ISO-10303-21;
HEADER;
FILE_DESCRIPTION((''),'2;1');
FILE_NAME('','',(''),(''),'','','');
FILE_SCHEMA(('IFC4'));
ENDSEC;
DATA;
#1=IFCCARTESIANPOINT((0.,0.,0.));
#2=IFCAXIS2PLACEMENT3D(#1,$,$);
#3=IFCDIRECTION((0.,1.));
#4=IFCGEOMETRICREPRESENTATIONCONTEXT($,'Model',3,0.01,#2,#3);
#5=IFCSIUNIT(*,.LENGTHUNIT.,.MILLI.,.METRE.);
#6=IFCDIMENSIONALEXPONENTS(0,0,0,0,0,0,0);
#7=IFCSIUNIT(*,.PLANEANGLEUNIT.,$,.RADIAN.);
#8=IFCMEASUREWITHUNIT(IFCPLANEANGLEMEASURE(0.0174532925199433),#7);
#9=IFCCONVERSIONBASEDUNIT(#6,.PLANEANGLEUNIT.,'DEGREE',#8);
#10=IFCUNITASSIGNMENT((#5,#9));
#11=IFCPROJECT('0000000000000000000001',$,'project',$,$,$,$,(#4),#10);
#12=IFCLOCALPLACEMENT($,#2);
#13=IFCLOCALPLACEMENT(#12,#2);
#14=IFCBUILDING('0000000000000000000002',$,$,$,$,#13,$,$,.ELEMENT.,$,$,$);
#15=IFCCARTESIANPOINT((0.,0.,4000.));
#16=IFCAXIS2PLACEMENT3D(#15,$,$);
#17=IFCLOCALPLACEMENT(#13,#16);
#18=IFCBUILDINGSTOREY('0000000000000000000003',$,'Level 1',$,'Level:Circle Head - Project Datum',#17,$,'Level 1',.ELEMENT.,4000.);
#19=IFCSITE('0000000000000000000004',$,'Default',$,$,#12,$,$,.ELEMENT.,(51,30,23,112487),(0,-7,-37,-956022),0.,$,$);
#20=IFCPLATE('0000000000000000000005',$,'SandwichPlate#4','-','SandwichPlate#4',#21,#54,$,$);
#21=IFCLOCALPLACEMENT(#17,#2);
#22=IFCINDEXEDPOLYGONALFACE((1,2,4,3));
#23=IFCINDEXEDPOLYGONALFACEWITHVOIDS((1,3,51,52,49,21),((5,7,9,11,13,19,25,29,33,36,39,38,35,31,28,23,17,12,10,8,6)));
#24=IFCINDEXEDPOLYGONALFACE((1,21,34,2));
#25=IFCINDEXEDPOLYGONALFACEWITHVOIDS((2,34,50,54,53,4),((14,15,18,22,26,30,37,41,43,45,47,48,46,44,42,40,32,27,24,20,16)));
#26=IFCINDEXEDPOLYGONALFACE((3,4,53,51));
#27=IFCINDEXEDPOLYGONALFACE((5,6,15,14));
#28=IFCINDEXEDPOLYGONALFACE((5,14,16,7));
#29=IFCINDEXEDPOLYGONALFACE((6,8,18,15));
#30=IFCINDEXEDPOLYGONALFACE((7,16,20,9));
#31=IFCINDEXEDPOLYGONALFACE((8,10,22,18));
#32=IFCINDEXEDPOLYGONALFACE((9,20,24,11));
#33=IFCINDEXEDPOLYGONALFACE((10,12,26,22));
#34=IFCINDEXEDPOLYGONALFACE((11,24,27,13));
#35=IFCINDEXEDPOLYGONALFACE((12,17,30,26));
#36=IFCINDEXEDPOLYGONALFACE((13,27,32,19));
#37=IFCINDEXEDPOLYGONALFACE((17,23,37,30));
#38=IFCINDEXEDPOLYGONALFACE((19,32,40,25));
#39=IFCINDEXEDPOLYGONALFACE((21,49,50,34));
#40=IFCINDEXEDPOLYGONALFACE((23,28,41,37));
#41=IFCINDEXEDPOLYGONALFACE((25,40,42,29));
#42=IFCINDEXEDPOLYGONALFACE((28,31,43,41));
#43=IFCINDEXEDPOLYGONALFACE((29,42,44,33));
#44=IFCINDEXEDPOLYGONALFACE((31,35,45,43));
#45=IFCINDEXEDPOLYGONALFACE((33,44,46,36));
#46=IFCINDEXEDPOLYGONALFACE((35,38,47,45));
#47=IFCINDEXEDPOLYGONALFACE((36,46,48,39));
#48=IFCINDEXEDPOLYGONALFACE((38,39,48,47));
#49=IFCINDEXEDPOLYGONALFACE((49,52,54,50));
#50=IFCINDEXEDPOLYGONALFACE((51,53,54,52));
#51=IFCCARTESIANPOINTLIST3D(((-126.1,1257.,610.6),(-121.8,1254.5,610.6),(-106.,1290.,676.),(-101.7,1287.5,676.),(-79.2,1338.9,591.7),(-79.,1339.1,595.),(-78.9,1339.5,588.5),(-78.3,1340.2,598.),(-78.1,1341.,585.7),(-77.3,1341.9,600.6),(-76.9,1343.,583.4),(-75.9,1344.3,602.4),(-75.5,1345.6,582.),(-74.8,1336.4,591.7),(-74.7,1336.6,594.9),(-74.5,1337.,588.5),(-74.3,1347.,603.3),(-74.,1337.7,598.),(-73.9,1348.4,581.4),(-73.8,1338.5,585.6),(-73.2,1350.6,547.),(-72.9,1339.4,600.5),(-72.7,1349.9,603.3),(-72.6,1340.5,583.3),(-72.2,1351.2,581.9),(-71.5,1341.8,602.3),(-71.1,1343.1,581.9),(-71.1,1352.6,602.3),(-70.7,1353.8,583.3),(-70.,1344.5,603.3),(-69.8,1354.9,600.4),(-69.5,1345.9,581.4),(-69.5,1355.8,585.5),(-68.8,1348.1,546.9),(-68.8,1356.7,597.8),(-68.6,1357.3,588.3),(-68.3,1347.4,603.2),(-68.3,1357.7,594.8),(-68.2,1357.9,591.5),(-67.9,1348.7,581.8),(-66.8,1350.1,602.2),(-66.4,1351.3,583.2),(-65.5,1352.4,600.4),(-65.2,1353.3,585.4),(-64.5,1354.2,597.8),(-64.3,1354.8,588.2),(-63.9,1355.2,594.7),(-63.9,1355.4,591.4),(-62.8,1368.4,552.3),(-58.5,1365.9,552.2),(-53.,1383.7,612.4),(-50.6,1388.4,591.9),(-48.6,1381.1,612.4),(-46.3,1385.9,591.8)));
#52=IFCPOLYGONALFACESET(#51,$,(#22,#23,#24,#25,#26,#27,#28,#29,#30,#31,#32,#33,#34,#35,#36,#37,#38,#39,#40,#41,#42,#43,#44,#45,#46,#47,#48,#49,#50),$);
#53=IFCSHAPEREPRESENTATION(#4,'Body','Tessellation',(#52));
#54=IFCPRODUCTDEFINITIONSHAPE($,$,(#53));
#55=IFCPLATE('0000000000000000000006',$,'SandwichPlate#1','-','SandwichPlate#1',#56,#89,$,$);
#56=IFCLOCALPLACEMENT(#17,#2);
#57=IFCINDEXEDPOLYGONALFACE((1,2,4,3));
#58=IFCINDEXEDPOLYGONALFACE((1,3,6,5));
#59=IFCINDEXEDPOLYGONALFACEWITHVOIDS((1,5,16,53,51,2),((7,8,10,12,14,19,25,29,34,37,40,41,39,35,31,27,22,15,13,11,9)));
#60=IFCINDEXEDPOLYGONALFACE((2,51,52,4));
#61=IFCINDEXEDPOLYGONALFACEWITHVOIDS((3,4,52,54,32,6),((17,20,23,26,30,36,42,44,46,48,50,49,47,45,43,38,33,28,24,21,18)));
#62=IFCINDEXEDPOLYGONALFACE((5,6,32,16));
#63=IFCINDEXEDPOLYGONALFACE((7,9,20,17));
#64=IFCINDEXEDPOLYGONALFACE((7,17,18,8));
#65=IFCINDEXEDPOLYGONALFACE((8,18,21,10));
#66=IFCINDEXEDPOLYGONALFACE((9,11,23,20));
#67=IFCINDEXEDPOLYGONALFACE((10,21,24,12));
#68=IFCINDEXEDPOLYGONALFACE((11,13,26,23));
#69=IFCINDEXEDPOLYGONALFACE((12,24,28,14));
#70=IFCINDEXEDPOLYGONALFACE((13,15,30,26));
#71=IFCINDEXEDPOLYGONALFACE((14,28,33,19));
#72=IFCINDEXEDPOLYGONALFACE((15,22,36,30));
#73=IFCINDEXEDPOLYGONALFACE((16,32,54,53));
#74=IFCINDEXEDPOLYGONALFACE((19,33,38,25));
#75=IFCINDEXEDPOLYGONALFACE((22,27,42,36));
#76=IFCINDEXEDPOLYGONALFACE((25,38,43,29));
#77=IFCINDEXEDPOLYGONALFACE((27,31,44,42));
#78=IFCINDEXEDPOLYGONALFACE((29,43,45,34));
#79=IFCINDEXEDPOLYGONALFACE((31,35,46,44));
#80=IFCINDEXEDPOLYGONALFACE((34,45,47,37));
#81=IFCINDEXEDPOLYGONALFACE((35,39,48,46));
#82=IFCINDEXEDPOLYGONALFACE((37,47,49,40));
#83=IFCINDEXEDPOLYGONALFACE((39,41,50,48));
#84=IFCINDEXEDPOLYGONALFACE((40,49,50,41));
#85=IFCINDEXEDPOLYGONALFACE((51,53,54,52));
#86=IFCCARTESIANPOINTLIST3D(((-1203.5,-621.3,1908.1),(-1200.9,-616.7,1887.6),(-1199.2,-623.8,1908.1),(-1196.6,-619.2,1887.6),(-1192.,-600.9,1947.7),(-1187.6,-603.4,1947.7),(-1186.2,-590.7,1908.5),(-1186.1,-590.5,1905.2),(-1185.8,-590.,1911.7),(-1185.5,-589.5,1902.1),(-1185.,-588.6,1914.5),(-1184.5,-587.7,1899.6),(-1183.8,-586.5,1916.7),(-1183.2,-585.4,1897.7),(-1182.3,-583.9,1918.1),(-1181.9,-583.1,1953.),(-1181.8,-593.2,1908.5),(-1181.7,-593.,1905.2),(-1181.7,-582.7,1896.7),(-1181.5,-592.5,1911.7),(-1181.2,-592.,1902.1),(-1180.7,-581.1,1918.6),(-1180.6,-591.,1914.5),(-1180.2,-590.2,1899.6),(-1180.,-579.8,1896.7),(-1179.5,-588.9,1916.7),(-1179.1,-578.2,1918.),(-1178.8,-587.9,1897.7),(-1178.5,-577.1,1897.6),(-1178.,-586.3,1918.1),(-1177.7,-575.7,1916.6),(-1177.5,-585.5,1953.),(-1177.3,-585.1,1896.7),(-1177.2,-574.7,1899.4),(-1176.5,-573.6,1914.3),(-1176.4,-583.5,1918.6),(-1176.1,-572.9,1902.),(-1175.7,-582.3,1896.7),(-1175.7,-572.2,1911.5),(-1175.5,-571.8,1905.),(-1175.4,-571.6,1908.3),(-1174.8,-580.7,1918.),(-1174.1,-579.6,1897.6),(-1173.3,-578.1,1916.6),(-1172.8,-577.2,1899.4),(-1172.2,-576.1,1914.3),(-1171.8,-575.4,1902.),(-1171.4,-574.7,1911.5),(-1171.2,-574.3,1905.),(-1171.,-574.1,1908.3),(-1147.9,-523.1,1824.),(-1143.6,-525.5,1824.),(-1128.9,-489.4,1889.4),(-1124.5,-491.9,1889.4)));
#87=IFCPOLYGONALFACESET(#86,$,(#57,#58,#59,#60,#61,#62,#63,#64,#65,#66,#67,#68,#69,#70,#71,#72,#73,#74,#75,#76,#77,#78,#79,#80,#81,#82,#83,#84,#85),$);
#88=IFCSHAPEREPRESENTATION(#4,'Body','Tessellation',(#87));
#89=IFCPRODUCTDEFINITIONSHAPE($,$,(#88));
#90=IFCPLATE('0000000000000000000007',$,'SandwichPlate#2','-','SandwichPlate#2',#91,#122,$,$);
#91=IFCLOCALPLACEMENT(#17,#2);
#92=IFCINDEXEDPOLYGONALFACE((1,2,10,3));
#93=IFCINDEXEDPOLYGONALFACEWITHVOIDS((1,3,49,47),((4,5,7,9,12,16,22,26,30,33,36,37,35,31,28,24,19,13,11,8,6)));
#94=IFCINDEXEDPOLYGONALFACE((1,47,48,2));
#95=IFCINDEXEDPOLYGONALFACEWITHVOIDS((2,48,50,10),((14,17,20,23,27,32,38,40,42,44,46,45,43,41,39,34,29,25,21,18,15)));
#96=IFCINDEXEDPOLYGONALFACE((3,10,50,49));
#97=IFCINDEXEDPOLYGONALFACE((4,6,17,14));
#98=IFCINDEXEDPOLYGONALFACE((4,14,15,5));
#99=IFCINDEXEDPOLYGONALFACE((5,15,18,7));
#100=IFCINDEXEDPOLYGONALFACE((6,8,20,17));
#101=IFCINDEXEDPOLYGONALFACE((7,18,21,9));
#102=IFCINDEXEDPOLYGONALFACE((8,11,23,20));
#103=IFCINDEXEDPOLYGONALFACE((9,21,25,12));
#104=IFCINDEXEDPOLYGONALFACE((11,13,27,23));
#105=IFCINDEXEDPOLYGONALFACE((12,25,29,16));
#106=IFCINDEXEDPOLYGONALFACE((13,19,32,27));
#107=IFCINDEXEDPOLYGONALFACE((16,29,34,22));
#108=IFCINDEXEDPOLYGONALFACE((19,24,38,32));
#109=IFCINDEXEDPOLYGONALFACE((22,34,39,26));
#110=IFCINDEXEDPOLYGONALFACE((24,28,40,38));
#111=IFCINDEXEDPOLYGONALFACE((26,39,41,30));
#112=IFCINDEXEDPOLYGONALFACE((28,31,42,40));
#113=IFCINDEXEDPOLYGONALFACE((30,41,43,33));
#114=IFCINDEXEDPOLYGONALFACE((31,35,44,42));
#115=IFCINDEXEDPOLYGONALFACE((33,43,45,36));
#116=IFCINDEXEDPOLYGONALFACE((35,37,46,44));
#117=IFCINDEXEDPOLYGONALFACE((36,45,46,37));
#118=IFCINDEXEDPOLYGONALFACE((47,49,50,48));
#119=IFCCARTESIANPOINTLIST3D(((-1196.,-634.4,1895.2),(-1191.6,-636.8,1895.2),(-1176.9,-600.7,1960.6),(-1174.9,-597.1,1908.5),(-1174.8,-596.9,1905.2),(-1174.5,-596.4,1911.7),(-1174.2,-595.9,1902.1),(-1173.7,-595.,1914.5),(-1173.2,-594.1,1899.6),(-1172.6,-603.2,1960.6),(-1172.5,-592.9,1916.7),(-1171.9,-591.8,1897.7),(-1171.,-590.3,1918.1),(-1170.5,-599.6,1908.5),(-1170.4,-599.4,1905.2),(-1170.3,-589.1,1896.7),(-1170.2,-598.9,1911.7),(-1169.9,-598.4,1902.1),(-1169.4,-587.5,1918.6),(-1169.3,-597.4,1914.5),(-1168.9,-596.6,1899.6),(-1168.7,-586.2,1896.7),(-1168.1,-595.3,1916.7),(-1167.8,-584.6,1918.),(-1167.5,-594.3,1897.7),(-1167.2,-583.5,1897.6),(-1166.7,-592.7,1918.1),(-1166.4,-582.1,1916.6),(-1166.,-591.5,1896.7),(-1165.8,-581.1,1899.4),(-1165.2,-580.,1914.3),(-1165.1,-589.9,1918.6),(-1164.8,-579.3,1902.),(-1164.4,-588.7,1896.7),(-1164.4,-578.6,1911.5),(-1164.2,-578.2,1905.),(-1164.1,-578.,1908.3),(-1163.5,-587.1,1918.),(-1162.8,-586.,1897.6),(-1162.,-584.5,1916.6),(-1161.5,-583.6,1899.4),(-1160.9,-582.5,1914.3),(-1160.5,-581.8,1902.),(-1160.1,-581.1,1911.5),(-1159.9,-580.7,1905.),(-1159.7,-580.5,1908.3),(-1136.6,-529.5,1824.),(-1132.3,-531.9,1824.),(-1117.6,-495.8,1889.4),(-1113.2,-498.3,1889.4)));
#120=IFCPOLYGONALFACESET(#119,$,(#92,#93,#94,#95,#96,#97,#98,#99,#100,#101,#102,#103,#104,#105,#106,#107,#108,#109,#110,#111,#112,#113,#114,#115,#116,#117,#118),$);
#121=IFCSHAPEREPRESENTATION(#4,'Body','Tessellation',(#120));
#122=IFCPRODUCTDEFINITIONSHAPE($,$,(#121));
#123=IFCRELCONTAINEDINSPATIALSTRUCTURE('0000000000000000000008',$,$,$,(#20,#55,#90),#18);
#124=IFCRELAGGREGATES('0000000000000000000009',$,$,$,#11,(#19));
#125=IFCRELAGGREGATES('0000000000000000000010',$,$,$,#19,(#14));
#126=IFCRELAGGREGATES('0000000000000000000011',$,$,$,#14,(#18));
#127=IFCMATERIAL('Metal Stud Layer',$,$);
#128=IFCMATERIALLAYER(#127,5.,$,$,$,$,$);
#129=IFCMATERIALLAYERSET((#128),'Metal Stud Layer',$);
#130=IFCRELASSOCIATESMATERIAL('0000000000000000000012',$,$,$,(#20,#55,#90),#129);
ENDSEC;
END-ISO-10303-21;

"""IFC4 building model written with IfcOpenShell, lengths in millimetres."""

from ifc_helpers import new_model, entity, si_unit, converted_unit, direction, frame, origin, origin_with_axes, origin_2d_with_axis, place, context, project, spatial, polyline, circle, outline, extrude, material, layer, layer_set, element, save


model = new_model("IFC4")

# Units and contexts
model_context = context("Model", 3, precision=0.01, world=origin(), true_north=direction((0.0, 1.0)))
ifc_project = project(units=[si_unit("LENGTHUNIT", "METRE", prefix="MILLI"), converted_unit("PLANEANGLEUNIT", "DEGREE", entity("IfcPlaneAngleMeasure", 0.0174532925199433), si_unit("PLANEANGLEUNIT", "RADIAN"), dimensions=[0, 0, 0, 0, 0, 0, 0])], contexts=[model_context])

# Site, building, storey
site_placement = place(None, origin())
site = spatial("IfcSite", under=ifc_project, at=site_placement, Name="Default", CompositionType="ELEMENT", RefLatitude=(51, 30, 23, 112487), RefLongitude=(0, -7, -37, -956022), RefElevation=0.0)
building_placement = place(site_placement, origin())
building = spatial("IfcBuilding", under=site, at=building_placement, CompositionType="ELEMENT")
storey_placement = place(building_placement, frame((0.0, 0.0, 4000.0)))
storey = spatial("IfcBuildingStorey", under=building, at=storey_placement, Name="Level 1", ObjectType="Level:Circle Head - Project Datum", LongName="Level 1", CompositionType="ELEMENT", Elevation=4000.0)

# Plate, openings
ifc_material_1 = material(Name="Metal Stud Layer")
ifc_layer_1 = layer(ifc_material_1, 5.0)
ifc_layer_set_1 = layer_set([ifc_layer_1], Name="Metal Stud Layer")
plate_1_placement = place(storey_placement, frame((-66.8, 1361.9, 539.4), z_axis=(0.865935, -0.499948, -0.014432), x_axis=(0.265222, 0.434531, 0.86072)))
plate_1 = element("IfcPlate", 1, at=plate_1_placement, inside=storey, material=ifc_layer_set_1, Name="SandwichPlate#4", Description="-", ObjectType="SandwichPlate#4", context=model_context, shape_type="SweptSolid", body=[
    extrude(outline(polyline([(0.0, 0.0), (76.0, 0.0), (76.0, 140.0), (0.0, 140.0), (0.0, 0.0)])), origin_with_axes(), (0.0, 0.0, 1.0), 5.0),
])
opening_1_placement = place(plate_1_placement, frame((0.0, 0.0, 0.0), z_axis=(0.0, 0.0, 1.0), x_axis=(1.0, 0.0, 0.0)))
element("IfcOpeningElement", 2, at=opening_1_placement, cuts=plate_1, ObjectType="Opening", context=model_context, shape_type="SweptSolid", body=[
    extrude(outline(polyline([(0.0, 0.0), (15.0, 0.0), (0.0, 15.0), (0.0, 0.0)])), origin(), (0.0, 0.0, 1.0), 5.0),
])
opening_2_placement = place(plate_1_placement, frame((0.0, 0.0, 0.0), z_axis=(0.0, 0.0, 1.0), x_axis=(1.0, 0.0, 0.0)))
element("IfcOpeningElement", 3, at=opening_2_placement, cuts=plate_1, ObjectType="Opening", context=model_context, shape_type="SweptSolid", body=[
    extrude(outline(polyline([(76.0, 0.0), (76.0, 15.0), (61.0, 0.0), (76.0, 0.0)])), origin(), (0.0, 0.0, 1.0), 5.0),
])
opening_3_placement = place(plate_1_placement, frame((38.0, 40.0, -0.5), z_axis=(0.0, 0.0, 1.0), x_axis=(0.0, 1.0, 0.0)))
element("IfcOpeningElement", 4, at=opening_3_placement, cuts=plate_1, ObjectType="Opening", context=model_context, shape_type="SweptSolid", body=[
    extrude(circle(Radius=11.0, at=origin_2d_with_axis()), origin(), (0.0, 0.0, 1.0), 6.0),
])

# Plates, openings
plate_2_placement = place(storey_placement, frame((-1188.2, -594.3, 1960.6), z_axis=(0.87026, -0.492593, 0.0), x_axis=(-0.250667, -0.442852, -0.860841)))
plate_2 = element("IfcPlate", 5, at=plate_2_placement, inside=storey, material=ifc_layer_set_1, Name="SandwichPlate#1", Description="-", ObjectType="SandwichPlate#1", context=model_context, shape_type="SweptSolid", body=[
    extrude(outline(polyline([(15.0, 0.0), (61.0, 0.0), (76.0, 15.0), (76.0, 140.0), (0.0, 140.0), (0.0, 15.0), (15.0, 0.0)])), origin_with_axes(), (0.0, 0.0, 1.0), 5.0),
])
opening_4_placement = place(plate_2_placement, frame((38.0, 40.0, -0.5), z_axis=(0.0, 0.0, 1.0), x_axis=(0.0, 1.0, 0.0)))
element("IfcOpeningElement", 6, at=opening_4_placement, cuts=plate_2, ObjectType="Opening", context=model_context, shape_type="SweptSolid", body=[
    extrude(circle(Radius=11.0, at=origin_2d_with_axis()), origin(), (0.0, 0.0, 1.0), 6.0),
])
plate_3_placement = place(storey_placement, frame((-1176.9, -600.7, 1960.6), z_axis=(0.87026, -0.492593, 0.0), x_axis=(-0.250667, -0.442852, -0.860841)))
plate_3 = element("IfcPlate", 7, at=plate_3_placement, inside=storey, material=ifc_layer_set_1, Name="SandwichPlate#2", Description="-", ObjectType="SandwichPlate#2", context=model_context, shape_type="SweptSolid", body=[
    extrude(outline(polyline([(0.0, 0.0), (76.0, 0.0), (76.0, 140.0), (0.0, 140.0), (0.0, 0.0)])), origin_with_axes(), (0.0, 0.0, 1.0), 5.0),
])
opening_5_placement = place(plate_3_placement, frame((38.0, 40.0, -0.5), z_axis=(0.0, 0.0, 1.0), x_axis=(0.0, 1.0, 0.0)))
element("IfcOpeningElement", 8, at=opening_5_placement, cuts=plate_3, ObjectType="Opening", context=model_context, shape_type="SweptSolid", body=[
    extrude(circle(Radius=11.0, at=origin_2d_with_axis()), origin(), (0.0, 0.0, 1.0), 6.0),
])

save(model, "model.ifc")
